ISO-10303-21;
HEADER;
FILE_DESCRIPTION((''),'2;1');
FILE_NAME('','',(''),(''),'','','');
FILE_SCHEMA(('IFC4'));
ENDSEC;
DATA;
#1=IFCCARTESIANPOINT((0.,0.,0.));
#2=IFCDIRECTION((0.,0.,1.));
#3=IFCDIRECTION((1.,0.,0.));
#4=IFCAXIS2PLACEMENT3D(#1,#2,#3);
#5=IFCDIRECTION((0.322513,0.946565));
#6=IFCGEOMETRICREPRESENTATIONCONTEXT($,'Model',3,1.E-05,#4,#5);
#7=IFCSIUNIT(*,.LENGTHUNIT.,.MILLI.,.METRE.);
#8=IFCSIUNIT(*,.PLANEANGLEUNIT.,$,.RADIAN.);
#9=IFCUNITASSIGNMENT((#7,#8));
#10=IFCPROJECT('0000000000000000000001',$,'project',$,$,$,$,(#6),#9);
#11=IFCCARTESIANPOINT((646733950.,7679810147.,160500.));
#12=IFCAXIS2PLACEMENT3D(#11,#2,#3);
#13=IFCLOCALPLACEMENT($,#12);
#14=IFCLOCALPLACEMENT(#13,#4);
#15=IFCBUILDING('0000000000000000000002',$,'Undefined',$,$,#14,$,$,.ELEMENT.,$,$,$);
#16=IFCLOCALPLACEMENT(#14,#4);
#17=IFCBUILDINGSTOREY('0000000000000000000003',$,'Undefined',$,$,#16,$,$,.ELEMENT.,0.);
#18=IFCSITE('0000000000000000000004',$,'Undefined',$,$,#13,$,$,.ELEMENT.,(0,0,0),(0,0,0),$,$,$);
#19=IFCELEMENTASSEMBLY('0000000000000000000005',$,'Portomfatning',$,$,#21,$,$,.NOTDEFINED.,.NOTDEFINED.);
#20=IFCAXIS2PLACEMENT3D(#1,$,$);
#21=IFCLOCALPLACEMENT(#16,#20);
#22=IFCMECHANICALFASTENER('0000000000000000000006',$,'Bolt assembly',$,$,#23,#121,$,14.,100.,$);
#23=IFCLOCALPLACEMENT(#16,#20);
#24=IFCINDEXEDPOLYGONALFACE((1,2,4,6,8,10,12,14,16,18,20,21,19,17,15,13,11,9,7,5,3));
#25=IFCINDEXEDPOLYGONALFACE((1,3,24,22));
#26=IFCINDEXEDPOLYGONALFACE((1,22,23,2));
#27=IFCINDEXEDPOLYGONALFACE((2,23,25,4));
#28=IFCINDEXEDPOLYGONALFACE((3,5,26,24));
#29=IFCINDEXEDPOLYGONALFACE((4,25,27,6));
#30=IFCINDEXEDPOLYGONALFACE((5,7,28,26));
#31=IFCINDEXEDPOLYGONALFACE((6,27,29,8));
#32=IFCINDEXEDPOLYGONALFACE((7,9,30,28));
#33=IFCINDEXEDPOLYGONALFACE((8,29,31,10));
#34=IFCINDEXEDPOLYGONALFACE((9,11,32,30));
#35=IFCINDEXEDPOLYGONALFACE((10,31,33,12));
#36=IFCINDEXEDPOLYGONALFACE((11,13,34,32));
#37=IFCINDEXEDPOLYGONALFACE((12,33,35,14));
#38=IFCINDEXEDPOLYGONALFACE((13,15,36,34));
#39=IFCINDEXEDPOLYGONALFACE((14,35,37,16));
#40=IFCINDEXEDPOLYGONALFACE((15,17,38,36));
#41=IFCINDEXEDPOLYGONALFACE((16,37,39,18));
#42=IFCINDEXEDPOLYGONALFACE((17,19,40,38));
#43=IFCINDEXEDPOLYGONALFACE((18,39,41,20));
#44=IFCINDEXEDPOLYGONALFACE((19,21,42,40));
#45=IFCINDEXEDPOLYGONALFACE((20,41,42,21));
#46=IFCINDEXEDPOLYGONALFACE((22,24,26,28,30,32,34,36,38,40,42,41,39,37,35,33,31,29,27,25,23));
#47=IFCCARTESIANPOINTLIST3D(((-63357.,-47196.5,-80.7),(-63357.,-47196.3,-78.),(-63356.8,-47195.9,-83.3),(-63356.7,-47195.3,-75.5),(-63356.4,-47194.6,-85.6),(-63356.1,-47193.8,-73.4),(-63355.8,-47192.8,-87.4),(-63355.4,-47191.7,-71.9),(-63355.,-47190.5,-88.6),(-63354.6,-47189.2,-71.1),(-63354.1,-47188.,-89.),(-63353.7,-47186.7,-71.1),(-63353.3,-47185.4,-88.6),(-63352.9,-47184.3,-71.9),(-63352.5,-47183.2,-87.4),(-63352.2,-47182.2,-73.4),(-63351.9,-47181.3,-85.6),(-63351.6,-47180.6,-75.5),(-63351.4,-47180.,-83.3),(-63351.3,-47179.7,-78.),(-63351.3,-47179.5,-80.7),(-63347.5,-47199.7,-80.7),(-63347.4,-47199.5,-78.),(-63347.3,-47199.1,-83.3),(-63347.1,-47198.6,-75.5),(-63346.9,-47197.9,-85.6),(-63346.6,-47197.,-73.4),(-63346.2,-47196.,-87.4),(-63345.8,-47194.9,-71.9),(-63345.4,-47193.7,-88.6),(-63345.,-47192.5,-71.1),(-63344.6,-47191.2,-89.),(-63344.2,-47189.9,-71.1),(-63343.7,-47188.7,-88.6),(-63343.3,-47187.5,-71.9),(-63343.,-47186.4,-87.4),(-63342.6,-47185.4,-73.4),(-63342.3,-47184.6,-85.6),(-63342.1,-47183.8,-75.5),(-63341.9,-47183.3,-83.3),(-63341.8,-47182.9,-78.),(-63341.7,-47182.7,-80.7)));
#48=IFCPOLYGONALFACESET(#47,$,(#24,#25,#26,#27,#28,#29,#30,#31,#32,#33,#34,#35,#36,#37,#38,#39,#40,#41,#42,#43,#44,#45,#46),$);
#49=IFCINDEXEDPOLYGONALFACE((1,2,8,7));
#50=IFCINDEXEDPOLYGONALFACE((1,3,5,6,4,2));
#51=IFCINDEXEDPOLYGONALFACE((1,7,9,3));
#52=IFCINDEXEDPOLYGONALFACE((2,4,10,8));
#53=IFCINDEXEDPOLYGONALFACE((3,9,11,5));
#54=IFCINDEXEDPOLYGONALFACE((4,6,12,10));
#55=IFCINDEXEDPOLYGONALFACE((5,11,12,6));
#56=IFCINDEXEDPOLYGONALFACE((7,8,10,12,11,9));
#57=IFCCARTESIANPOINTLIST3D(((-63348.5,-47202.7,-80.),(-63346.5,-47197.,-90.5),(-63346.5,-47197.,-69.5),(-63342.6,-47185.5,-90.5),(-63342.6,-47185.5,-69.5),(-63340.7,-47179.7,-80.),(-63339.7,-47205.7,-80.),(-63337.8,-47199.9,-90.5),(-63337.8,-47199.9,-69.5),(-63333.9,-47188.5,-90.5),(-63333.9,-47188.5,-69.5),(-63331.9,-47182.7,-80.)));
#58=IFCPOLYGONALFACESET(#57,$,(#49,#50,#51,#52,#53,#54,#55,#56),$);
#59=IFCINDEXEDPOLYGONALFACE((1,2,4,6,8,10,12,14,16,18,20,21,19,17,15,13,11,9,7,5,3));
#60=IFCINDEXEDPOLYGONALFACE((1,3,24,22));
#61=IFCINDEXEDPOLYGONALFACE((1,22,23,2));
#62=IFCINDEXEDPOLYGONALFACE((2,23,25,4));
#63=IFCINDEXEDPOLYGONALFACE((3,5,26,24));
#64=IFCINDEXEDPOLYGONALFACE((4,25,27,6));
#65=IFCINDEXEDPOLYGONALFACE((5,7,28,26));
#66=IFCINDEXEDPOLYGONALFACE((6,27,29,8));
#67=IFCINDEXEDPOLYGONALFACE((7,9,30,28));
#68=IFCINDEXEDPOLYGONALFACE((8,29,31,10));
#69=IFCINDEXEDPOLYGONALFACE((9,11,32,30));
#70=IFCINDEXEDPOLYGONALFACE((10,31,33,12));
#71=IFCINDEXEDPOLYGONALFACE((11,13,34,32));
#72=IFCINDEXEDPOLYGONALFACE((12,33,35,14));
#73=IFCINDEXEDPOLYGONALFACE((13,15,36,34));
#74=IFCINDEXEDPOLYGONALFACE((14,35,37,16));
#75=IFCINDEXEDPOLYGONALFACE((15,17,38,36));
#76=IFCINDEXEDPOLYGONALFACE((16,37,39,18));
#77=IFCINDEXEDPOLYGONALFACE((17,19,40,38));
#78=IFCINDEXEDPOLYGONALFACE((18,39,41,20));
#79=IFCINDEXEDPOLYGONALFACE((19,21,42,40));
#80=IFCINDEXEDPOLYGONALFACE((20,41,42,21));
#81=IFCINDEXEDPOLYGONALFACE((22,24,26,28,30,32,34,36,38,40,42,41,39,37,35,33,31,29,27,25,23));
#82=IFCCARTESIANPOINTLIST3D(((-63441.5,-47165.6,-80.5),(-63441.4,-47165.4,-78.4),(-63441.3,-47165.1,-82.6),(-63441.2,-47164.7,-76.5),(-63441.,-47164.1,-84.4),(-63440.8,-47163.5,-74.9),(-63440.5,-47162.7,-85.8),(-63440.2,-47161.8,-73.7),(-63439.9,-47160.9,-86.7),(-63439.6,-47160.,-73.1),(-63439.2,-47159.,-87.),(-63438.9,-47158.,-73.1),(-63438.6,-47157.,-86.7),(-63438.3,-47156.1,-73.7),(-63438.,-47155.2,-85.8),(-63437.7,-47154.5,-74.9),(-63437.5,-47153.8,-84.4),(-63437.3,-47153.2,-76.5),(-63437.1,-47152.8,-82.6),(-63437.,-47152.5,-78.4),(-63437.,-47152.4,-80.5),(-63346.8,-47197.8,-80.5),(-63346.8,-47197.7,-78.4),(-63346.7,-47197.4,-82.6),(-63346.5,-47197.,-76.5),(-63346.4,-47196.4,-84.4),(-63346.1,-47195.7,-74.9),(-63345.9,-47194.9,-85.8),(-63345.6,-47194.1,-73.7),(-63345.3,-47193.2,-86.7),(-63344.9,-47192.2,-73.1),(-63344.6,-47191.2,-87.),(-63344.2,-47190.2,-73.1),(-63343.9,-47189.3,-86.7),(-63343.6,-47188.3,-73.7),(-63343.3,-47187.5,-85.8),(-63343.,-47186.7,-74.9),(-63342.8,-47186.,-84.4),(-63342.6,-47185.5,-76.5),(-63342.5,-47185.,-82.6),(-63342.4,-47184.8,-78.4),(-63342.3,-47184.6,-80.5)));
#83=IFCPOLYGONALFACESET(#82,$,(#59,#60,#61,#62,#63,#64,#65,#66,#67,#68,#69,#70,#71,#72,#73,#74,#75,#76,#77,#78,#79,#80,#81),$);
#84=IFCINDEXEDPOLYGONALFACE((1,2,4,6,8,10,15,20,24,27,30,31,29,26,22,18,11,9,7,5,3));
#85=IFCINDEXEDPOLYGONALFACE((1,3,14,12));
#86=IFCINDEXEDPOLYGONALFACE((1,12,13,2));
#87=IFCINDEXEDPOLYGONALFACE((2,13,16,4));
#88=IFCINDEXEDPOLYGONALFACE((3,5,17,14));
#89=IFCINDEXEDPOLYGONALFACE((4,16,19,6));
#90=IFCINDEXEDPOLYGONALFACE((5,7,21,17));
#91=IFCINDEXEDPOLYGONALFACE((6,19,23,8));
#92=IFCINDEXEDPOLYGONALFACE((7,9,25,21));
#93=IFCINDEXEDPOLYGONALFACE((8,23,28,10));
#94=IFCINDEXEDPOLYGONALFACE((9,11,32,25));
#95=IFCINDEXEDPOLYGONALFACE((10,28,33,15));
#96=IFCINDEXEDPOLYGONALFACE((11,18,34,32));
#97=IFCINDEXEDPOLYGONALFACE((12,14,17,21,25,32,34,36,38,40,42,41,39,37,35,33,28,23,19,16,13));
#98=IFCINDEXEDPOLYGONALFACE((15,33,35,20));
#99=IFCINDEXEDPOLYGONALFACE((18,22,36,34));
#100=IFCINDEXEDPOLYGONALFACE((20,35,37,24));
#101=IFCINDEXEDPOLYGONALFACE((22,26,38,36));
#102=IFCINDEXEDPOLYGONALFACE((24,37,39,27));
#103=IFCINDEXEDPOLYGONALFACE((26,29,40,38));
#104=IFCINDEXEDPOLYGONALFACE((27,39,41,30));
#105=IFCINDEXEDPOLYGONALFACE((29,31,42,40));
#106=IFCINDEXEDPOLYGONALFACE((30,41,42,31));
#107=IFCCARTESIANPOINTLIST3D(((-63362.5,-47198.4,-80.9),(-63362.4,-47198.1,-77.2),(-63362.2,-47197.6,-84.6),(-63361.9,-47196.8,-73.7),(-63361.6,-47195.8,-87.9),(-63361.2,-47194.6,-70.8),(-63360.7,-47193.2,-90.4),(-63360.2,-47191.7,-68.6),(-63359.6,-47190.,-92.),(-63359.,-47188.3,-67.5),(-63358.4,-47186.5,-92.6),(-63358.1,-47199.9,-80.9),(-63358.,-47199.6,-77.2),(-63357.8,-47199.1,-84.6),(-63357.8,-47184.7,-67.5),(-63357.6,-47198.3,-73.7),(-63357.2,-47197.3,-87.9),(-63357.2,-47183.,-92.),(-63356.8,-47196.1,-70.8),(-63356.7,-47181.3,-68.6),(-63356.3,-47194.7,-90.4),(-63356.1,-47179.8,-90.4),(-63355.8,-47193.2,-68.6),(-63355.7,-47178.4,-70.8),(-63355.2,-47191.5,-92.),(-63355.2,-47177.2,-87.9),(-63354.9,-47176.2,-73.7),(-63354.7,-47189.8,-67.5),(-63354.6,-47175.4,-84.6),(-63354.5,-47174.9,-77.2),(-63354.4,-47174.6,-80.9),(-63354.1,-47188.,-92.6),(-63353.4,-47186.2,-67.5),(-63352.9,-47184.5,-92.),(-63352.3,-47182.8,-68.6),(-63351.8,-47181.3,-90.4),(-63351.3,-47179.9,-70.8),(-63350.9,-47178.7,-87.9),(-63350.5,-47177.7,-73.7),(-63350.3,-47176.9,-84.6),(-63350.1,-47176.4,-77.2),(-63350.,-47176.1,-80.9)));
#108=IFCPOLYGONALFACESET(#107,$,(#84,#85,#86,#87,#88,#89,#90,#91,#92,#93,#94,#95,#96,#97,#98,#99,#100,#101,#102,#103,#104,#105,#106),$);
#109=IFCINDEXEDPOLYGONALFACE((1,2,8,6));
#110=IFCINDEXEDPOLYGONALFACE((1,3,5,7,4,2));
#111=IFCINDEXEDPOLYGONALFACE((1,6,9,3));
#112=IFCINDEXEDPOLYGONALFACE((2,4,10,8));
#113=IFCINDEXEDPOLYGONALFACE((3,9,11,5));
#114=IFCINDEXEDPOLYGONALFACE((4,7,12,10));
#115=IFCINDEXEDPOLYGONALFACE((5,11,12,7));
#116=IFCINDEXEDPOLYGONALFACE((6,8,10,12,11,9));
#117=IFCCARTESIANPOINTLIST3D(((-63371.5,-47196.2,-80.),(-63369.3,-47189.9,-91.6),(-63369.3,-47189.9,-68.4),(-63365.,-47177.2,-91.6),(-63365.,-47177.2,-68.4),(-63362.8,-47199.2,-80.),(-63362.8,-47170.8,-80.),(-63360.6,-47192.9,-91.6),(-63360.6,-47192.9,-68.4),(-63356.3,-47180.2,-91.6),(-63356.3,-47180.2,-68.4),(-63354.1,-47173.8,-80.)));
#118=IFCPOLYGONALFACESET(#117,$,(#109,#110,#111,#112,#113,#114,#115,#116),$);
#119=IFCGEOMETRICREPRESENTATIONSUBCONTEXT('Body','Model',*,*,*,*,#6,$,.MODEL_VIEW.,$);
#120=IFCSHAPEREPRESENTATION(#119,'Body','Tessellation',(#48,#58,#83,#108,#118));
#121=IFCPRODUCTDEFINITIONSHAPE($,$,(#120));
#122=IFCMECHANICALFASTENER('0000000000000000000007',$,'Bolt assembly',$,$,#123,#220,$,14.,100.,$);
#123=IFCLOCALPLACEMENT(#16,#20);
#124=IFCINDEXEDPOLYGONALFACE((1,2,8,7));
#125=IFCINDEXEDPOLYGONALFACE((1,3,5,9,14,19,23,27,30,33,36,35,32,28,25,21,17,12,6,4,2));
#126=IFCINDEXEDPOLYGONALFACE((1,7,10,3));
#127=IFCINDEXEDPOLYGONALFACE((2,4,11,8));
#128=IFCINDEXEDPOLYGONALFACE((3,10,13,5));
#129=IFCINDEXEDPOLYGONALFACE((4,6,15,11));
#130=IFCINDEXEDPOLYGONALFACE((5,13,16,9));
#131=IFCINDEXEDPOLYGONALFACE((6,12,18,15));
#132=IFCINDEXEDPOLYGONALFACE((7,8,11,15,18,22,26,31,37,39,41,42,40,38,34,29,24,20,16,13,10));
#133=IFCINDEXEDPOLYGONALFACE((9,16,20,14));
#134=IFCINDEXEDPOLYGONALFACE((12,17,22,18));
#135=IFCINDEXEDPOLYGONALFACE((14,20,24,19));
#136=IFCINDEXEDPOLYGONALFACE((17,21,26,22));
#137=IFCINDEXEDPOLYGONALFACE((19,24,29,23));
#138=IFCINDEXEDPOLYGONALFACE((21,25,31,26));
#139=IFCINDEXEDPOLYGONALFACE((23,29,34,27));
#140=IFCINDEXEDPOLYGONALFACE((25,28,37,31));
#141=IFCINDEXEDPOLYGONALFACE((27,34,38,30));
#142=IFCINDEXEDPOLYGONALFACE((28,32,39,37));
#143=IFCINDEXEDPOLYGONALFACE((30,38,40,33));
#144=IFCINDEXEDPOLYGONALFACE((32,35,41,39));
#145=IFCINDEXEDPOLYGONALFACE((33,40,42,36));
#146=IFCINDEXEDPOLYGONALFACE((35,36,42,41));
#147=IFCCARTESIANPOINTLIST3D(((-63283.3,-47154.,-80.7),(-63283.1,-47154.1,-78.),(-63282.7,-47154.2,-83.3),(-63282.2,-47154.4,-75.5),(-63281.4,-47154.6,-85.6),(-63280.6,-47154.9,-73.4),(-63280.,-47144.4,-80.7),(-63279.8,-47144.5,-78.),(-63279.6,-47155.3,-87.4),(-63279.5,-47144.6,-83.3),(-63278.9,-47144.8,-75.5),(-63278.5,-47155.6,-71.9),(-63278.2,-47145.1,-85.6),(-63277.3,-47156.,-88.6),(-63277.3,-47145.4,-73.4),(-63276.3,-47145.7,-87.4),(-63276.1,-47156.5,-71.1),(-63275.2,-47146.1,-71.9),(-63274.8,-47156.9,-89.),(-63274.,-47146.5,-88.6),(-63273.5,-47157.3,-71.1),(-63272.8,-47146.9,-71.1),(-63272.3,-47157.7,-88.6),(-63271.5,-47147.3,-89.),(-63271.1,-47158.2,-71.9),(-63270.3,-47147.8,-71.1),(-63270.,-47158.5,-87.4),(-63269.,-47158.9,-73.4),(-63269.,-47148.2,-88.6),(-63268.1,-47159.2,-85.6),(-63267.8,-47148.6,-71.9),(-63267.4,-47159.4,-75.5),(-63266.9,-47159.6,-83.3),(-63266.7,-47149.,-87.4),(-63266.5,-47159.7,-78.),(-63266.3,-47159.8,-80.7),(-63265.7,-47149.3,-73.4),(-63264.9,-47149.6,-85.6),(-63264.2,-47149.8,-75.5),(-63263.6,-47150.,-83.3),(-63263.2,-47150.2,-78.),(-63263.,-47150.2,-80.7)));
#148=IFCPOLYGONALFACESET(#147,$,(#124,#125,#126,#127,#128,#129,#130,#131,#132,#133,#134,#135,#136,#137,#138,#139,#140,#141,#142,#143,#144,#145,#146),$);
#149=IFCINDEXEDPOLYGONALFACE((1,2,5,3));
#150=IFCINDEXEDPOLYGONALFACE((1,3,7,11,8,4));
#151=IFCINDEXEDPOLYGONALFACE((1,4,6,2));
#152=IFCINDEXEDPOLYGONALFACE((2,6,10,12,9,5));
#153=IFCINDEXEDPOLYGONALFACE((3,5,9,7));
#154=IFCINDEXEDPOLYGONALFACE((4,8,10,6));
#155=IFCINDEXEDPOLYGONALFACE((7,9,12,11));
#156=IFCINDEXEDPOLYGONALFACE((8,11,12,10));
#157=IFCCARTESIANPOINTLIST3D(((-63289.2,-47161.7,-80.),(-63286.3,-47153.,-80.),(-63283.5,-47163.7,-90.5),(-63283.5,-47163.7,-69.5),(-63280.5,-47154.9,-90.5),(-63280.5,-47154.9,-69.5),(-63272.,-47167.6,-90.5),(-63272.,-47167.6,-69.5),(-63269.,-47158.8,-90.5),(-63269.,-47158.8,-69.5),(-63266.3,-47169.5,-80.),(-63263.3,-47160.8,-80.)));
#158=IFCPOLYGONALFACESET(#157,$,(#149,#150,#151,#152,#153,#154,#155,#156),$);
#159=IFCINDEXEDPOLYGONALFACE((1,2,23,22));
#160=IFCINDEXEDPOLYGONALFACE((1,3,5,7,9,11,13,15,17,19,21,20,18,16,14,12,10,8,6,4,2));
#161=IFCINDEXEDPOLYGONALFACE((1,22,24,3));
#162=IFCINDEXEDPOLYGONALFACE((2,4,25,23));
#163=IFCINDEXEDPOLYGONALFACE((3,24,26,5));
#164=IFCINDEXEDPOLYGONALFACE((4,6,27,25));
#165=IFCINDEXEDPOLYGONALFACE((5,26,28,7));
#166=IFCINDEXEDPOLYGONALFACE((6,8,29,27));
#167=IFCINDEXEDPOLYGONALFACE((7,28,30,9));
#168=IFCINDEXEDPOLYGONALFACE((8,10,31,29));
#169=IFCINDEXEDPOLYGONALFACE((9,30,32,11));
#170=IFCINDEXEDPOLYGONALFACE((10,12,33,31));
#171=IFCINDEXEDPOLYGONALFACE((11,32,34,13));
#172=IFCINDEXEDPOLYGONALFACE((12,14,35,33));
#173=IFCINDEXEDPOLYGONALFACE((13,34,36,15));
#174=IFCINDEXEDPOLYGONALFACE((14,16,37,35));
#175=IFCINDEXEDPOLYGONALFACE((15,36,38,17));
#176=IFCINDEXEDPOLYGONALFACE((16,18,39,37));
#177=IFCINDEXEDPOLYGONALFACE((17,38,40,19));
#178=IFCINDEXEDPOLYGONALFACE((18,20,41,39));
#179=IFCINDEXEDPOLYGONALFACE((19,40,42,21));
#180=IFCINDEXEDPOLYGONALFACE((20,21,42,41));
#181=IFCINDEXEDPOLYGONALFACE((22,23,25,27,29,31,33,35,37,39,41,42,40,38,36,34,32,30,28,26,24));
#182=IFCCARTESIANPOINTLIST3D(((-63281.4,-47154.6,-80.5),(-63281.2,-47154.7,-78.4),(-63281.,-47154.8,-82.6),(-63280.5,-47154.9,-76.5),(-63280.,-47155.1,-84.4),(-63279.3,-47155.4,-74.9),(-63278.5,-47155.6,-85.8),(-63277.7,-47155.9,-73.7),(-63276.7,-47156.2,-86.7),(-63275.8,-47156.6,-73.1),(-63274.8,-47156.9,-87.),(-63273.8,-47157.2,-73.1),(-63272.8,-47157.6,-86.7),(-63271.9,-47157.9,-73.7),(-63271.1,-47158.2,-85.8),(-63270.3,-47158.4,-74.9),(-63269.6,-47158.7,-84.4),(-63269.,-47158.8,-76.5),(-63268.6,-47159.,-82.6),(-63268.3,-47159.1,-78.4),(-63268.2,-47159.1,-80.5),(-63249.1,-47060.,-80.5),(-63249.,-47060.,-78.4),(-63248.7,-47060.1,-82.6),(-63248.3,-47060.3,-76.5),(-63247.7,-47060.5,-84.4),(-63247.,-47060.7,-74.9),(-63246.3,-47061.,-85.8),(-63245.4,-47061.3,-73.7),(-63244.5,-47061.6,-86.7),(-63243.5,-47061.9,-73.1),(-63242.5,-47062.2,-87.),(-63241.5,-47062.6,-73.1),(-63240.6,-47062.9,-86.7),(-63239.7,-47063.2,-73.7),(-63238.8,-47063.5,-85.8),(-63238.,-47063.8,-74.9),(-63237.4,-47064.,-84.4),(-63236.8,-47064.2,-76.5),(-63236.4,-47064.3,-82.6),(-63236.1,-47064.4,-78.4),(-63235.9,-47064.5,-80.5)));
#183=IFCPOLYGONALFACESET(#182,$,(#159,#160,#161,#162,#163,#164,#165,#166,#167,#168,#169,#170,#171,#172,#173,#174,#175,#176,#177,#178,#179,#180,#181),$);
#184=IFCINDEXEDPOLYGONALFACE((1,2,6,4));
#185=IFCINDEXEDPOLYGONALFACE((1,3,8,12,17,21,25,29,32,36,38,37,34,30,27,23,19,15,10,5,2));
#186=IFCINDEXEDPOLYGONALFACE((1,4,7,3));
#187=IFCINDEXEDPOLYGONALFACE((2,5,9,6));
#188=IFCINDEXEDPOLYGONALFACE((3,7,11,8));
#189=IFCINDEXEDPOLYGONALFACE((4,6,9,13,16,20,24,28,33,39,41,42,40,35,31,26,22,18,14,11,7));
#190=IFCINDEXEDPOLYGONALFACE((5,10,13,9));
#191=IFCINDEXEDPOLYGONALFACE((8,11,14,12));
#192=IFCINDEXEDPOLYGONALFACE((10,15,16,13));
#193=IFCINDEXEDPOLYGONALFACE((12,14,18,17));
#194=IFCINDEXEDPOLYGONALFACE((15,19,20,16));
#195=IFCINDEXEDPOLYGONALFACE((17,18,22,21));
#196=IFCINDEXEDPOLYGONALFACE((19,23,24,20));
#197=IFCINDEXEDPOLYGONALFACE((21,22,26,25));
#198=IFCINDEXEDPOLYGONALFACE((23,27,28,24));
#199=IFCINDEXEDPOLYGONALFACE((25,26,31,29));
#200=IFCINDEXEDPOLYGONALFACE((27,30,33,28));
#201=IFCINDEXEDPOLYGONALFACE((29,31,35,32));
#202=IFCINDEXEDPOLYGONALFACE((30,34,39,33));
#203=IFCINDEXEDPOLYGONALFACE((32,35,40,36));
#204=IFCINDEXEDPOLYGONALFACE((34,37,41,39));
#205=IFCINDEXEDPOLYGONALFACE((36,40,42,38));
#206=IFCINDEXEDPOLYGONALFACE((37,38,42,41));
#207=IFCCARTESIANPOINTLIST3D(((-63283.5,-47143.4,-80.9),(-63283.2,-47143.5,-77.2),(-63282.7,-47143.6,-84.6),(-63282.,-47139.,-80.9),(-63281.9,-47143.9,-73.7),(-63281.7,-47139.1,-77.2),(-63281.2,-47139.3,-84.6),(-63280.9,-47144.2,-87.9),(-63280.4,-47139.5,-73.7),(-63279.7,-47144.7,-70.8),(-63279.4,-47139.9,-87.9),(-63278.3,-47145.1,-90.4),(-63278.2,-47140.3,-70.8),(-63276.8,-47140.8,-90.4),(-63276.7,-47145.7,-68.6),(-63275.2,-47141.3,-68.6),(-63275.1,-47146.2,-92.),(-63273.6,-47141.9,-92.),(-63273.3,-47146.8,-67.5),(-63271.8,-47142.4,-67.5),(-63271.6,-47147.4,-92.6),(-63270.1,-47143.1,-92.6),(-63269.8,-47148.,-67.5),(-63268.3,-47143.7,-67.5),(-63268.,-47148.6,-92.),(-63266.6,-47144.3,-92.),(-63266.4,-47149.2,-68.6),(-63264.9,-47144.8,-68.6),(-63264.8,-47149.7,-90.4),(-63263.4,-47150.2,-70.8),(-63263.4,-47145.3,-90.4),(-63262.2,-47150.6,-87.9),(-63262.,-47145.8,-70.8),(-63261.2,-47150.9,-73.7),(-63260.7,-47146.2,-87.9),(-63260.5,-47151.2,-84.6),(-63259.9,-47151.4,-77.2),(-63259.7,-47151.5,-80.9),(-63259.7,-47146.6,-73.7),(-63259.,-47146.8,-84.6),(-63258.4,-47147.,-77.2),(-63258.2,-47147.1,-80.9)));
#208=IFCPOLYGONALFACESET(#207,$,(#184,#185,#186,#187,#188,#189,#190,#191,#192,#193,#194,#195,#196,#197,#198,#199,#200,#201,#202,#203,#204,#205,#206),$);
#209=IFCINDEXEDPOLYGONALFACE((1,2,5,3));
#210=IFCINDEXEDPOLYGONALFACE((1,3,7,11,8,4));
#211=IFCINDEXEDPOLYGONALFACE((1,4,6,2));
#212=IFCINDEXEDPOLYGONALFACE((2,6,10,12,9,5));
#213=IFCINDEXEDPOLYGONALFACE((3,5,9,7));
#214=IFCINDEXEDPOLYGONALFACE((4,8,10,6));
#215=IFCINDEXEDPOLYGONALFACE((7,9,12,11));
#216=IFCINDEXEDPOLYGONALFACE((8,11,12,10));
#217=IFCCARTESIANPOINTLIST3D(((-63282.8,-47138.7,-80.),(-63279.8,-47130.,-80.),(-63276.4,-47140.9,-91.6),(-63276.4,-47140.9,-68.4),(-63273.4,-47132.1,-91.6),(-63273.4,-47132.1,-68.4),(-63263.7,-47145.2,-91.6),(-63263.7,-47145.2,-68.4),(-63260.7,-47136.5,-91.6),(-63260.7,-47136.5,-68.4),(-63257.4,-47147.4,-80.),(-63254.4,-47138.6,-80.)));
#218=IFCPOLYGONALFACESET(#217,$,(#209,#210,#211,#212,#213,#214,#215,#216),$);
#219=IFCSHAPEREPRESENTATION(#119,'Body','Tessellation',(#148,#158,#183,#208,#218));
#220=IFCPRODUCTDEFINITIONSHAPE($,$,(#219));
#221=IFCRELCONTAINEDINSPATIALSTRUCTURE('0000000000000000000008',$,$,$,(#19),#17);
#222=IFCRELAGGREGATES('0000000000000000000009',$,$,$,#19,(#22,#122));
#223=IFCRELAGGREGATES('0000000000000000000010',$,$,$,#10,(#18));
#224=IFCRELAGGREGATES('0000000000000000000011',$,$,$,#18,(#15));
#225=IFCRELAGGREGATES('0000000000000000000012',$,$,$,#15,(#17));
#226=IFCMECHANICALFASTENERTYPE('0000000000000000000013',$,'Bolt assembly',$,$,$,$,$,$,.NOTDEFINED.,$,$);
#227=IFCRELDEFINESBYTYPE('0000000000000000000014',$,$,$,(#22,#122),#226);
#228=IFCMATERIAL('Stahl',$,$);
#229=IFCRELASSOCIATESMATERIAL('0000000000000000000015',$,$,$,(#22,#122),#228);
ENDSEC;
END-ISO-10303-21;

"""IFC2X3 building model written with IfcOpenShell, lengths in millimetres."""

from ifc_helpers import new_model, si_unit, direction, frame, origin_with_axes, origin_2d_with_axis, place, context, subcontext, project, spatial, polyline, circle, outline, extrude, source, transform, mapped, material, type_object, element, aggregate, save


model = new_model("IFC2X3")

# Units and contexts
model_context = context("Model", 3, precision=1e-05, world=origin_with_axes(), true_north=direction((0.322513, 0.946565)))
body_context = subcontext(model_context, "Body", "Model", "MODEL_VIEW")
ifc_project = project(units=[si_unit("LENGTHUNIT", "METRE", prefix="MILLI"), si_unit("PLANEANGLEUNIT", "RADIAN")], contexts=[model_context])

# Site, building, storey
site_placement = place(None, frame((646733950.0, 7679810147.0, 160500.0), z_axis=(0.0, 0.0, 1.0), x_axis=(1.0, 0.0, 0.0)))
site = spatial("IfcSite", under=ifc_project, at=site_placement, Name="Undefined", CompositionType="ELEMENT", RefLatitude=(0, 0, 0), RefLongitude=(0, 0, 0))
building_placement = place(site_placement, origin_with_axes())
building = spatial("IfcBuilding", under=site, at=building_placement, Name="Undefined", CompositionType="ELEMENT")
storey_placement = place(building_placement, origin_with_axes())
storey = spatial("IfcBuildingStorey", under=building, at=storey_placement, Name="Undefined", CompositionType="ELEMENT", Elevation=0.0)

# Element assembly
assembly_1_placement = place(storey_placement, origin_with_axes())
assembly_1 = element("IfcElementAssembly", 1, at=assembly_1_placement, inside=storey, Name="Portomfatning", AssemblyPlace="NOTDEFINED", PredefinedType="NOTDEFINED")

# Mechanical fasteners
mechanical_fastener_type = type_object("IfcMechanicalFastenerType", Name="Bolt assembly")
ifc_material_1 = material(Name="Stahl")
shared_shape_1 = source(origin_with_axes(), body_context, "Body", "SweptSolid", [
    extrude(circle(Radius=9.0, at=origin_2d_with_axis()), frame((0.0, -10.0, 0.0), z_axis=(0.0, 1.0, 0.0), x_axis=(1.0, 0.0, 0.0)), (0.0, 0.0, 1.0), 10.1),
    extrude(outline(polyline([(10.5, -6.1), (10.5, 6.1), (0.0, 12.1), (-10.5, 6.1), (-10.5, -6.1), (0.0, -12.1), (10.5, -6.1)])), frame((0.0, -19.2, 0.0), z_axis=(0.0, 1.0, 0.0), x_axis=(1.0, 0.0, 0.0)), (0.0, 0.0, 1.0), 9.2),
    extrude(circle(Radius=7.0, at=origin_2d_with_axis()), frame((0.0, -10.0, 0.0), z_axis=(0.0, 1.0, 0.0), x_axis=(1.0, 0.0, 0.0)), (0.0, 0.0, 1.0), 100.0),
    extrude(circle(Radius=12.6, at=origin_2d_with_axis()), frame((0.0, 0.0, 0.0), z_axis=(0.0, 1.0, 0.0), x_axis=(1.0, 0.0, 0.0)), (0.0, 0.0, 1.0), 4.6),
    extrude(outline(polyline([(11.6, -6.7), (11.6, 6.7), (0.0, 13.4), (-11.6, 6.7), (-11.6, -6.7), (0.0, -13.4), (11.6, -6.7)])), frame((0.0, 4.6, 0.0), z_axis=(0.0, 1.0, 0.0), x_axis=(1.0, 0.0, 0.0)), (0.0, 0.0, 1.0), 9.2),
])
mechanical_fastener_1_placement = place(assembly_1_placement, frame((-63354.1, -47188.0, -80.0), z_axis=(0.322513, 0.946565, -0.000025), x_axis=(-0.000008, -0.000024, -1.0)))
mechanical_fastener_1 = element("IfcMechanicalFastener", 2, at=mechanical_fastener_1_placement, type_object=mechanical_fastener_type, material=ifc_material_1, Name="Bolt assembly", NominalDiameter=14.0, NominalLength=100.0, context=body_context, shape_type="MappedRepresentation", body=[
    mapped(shared_shape_1, transform((0.0, 0.0, 0.0))),
])
mechanical_fastener_2_placement = place(assembly_1_placement, frame((-63271.6, -47147.4, -80.0), z_axis=(0.946565, -0.322513, -0.000025), x_axis=(-0.000024, 0.000008, -1.0)))
mechanical_fastener_2 = element("IfcMechanicalFastener", 3, at=mechanical_fastener_2_placement, type_object=mechanical_fastener_type, material=ifc_material_1, Name="Bolt assembly", NominalDiameter=14.0, NominalLength=100.0, context=body_context, shape_type="MappedRepresentation", body=[
    mapped(shared_shape_1, transform((0.0, 0.0, 0.0))),
])
aggregate(assembly_1, [mechanical_fastener_1, mechanical_fastener_2])

save(model, "model.ifc")
